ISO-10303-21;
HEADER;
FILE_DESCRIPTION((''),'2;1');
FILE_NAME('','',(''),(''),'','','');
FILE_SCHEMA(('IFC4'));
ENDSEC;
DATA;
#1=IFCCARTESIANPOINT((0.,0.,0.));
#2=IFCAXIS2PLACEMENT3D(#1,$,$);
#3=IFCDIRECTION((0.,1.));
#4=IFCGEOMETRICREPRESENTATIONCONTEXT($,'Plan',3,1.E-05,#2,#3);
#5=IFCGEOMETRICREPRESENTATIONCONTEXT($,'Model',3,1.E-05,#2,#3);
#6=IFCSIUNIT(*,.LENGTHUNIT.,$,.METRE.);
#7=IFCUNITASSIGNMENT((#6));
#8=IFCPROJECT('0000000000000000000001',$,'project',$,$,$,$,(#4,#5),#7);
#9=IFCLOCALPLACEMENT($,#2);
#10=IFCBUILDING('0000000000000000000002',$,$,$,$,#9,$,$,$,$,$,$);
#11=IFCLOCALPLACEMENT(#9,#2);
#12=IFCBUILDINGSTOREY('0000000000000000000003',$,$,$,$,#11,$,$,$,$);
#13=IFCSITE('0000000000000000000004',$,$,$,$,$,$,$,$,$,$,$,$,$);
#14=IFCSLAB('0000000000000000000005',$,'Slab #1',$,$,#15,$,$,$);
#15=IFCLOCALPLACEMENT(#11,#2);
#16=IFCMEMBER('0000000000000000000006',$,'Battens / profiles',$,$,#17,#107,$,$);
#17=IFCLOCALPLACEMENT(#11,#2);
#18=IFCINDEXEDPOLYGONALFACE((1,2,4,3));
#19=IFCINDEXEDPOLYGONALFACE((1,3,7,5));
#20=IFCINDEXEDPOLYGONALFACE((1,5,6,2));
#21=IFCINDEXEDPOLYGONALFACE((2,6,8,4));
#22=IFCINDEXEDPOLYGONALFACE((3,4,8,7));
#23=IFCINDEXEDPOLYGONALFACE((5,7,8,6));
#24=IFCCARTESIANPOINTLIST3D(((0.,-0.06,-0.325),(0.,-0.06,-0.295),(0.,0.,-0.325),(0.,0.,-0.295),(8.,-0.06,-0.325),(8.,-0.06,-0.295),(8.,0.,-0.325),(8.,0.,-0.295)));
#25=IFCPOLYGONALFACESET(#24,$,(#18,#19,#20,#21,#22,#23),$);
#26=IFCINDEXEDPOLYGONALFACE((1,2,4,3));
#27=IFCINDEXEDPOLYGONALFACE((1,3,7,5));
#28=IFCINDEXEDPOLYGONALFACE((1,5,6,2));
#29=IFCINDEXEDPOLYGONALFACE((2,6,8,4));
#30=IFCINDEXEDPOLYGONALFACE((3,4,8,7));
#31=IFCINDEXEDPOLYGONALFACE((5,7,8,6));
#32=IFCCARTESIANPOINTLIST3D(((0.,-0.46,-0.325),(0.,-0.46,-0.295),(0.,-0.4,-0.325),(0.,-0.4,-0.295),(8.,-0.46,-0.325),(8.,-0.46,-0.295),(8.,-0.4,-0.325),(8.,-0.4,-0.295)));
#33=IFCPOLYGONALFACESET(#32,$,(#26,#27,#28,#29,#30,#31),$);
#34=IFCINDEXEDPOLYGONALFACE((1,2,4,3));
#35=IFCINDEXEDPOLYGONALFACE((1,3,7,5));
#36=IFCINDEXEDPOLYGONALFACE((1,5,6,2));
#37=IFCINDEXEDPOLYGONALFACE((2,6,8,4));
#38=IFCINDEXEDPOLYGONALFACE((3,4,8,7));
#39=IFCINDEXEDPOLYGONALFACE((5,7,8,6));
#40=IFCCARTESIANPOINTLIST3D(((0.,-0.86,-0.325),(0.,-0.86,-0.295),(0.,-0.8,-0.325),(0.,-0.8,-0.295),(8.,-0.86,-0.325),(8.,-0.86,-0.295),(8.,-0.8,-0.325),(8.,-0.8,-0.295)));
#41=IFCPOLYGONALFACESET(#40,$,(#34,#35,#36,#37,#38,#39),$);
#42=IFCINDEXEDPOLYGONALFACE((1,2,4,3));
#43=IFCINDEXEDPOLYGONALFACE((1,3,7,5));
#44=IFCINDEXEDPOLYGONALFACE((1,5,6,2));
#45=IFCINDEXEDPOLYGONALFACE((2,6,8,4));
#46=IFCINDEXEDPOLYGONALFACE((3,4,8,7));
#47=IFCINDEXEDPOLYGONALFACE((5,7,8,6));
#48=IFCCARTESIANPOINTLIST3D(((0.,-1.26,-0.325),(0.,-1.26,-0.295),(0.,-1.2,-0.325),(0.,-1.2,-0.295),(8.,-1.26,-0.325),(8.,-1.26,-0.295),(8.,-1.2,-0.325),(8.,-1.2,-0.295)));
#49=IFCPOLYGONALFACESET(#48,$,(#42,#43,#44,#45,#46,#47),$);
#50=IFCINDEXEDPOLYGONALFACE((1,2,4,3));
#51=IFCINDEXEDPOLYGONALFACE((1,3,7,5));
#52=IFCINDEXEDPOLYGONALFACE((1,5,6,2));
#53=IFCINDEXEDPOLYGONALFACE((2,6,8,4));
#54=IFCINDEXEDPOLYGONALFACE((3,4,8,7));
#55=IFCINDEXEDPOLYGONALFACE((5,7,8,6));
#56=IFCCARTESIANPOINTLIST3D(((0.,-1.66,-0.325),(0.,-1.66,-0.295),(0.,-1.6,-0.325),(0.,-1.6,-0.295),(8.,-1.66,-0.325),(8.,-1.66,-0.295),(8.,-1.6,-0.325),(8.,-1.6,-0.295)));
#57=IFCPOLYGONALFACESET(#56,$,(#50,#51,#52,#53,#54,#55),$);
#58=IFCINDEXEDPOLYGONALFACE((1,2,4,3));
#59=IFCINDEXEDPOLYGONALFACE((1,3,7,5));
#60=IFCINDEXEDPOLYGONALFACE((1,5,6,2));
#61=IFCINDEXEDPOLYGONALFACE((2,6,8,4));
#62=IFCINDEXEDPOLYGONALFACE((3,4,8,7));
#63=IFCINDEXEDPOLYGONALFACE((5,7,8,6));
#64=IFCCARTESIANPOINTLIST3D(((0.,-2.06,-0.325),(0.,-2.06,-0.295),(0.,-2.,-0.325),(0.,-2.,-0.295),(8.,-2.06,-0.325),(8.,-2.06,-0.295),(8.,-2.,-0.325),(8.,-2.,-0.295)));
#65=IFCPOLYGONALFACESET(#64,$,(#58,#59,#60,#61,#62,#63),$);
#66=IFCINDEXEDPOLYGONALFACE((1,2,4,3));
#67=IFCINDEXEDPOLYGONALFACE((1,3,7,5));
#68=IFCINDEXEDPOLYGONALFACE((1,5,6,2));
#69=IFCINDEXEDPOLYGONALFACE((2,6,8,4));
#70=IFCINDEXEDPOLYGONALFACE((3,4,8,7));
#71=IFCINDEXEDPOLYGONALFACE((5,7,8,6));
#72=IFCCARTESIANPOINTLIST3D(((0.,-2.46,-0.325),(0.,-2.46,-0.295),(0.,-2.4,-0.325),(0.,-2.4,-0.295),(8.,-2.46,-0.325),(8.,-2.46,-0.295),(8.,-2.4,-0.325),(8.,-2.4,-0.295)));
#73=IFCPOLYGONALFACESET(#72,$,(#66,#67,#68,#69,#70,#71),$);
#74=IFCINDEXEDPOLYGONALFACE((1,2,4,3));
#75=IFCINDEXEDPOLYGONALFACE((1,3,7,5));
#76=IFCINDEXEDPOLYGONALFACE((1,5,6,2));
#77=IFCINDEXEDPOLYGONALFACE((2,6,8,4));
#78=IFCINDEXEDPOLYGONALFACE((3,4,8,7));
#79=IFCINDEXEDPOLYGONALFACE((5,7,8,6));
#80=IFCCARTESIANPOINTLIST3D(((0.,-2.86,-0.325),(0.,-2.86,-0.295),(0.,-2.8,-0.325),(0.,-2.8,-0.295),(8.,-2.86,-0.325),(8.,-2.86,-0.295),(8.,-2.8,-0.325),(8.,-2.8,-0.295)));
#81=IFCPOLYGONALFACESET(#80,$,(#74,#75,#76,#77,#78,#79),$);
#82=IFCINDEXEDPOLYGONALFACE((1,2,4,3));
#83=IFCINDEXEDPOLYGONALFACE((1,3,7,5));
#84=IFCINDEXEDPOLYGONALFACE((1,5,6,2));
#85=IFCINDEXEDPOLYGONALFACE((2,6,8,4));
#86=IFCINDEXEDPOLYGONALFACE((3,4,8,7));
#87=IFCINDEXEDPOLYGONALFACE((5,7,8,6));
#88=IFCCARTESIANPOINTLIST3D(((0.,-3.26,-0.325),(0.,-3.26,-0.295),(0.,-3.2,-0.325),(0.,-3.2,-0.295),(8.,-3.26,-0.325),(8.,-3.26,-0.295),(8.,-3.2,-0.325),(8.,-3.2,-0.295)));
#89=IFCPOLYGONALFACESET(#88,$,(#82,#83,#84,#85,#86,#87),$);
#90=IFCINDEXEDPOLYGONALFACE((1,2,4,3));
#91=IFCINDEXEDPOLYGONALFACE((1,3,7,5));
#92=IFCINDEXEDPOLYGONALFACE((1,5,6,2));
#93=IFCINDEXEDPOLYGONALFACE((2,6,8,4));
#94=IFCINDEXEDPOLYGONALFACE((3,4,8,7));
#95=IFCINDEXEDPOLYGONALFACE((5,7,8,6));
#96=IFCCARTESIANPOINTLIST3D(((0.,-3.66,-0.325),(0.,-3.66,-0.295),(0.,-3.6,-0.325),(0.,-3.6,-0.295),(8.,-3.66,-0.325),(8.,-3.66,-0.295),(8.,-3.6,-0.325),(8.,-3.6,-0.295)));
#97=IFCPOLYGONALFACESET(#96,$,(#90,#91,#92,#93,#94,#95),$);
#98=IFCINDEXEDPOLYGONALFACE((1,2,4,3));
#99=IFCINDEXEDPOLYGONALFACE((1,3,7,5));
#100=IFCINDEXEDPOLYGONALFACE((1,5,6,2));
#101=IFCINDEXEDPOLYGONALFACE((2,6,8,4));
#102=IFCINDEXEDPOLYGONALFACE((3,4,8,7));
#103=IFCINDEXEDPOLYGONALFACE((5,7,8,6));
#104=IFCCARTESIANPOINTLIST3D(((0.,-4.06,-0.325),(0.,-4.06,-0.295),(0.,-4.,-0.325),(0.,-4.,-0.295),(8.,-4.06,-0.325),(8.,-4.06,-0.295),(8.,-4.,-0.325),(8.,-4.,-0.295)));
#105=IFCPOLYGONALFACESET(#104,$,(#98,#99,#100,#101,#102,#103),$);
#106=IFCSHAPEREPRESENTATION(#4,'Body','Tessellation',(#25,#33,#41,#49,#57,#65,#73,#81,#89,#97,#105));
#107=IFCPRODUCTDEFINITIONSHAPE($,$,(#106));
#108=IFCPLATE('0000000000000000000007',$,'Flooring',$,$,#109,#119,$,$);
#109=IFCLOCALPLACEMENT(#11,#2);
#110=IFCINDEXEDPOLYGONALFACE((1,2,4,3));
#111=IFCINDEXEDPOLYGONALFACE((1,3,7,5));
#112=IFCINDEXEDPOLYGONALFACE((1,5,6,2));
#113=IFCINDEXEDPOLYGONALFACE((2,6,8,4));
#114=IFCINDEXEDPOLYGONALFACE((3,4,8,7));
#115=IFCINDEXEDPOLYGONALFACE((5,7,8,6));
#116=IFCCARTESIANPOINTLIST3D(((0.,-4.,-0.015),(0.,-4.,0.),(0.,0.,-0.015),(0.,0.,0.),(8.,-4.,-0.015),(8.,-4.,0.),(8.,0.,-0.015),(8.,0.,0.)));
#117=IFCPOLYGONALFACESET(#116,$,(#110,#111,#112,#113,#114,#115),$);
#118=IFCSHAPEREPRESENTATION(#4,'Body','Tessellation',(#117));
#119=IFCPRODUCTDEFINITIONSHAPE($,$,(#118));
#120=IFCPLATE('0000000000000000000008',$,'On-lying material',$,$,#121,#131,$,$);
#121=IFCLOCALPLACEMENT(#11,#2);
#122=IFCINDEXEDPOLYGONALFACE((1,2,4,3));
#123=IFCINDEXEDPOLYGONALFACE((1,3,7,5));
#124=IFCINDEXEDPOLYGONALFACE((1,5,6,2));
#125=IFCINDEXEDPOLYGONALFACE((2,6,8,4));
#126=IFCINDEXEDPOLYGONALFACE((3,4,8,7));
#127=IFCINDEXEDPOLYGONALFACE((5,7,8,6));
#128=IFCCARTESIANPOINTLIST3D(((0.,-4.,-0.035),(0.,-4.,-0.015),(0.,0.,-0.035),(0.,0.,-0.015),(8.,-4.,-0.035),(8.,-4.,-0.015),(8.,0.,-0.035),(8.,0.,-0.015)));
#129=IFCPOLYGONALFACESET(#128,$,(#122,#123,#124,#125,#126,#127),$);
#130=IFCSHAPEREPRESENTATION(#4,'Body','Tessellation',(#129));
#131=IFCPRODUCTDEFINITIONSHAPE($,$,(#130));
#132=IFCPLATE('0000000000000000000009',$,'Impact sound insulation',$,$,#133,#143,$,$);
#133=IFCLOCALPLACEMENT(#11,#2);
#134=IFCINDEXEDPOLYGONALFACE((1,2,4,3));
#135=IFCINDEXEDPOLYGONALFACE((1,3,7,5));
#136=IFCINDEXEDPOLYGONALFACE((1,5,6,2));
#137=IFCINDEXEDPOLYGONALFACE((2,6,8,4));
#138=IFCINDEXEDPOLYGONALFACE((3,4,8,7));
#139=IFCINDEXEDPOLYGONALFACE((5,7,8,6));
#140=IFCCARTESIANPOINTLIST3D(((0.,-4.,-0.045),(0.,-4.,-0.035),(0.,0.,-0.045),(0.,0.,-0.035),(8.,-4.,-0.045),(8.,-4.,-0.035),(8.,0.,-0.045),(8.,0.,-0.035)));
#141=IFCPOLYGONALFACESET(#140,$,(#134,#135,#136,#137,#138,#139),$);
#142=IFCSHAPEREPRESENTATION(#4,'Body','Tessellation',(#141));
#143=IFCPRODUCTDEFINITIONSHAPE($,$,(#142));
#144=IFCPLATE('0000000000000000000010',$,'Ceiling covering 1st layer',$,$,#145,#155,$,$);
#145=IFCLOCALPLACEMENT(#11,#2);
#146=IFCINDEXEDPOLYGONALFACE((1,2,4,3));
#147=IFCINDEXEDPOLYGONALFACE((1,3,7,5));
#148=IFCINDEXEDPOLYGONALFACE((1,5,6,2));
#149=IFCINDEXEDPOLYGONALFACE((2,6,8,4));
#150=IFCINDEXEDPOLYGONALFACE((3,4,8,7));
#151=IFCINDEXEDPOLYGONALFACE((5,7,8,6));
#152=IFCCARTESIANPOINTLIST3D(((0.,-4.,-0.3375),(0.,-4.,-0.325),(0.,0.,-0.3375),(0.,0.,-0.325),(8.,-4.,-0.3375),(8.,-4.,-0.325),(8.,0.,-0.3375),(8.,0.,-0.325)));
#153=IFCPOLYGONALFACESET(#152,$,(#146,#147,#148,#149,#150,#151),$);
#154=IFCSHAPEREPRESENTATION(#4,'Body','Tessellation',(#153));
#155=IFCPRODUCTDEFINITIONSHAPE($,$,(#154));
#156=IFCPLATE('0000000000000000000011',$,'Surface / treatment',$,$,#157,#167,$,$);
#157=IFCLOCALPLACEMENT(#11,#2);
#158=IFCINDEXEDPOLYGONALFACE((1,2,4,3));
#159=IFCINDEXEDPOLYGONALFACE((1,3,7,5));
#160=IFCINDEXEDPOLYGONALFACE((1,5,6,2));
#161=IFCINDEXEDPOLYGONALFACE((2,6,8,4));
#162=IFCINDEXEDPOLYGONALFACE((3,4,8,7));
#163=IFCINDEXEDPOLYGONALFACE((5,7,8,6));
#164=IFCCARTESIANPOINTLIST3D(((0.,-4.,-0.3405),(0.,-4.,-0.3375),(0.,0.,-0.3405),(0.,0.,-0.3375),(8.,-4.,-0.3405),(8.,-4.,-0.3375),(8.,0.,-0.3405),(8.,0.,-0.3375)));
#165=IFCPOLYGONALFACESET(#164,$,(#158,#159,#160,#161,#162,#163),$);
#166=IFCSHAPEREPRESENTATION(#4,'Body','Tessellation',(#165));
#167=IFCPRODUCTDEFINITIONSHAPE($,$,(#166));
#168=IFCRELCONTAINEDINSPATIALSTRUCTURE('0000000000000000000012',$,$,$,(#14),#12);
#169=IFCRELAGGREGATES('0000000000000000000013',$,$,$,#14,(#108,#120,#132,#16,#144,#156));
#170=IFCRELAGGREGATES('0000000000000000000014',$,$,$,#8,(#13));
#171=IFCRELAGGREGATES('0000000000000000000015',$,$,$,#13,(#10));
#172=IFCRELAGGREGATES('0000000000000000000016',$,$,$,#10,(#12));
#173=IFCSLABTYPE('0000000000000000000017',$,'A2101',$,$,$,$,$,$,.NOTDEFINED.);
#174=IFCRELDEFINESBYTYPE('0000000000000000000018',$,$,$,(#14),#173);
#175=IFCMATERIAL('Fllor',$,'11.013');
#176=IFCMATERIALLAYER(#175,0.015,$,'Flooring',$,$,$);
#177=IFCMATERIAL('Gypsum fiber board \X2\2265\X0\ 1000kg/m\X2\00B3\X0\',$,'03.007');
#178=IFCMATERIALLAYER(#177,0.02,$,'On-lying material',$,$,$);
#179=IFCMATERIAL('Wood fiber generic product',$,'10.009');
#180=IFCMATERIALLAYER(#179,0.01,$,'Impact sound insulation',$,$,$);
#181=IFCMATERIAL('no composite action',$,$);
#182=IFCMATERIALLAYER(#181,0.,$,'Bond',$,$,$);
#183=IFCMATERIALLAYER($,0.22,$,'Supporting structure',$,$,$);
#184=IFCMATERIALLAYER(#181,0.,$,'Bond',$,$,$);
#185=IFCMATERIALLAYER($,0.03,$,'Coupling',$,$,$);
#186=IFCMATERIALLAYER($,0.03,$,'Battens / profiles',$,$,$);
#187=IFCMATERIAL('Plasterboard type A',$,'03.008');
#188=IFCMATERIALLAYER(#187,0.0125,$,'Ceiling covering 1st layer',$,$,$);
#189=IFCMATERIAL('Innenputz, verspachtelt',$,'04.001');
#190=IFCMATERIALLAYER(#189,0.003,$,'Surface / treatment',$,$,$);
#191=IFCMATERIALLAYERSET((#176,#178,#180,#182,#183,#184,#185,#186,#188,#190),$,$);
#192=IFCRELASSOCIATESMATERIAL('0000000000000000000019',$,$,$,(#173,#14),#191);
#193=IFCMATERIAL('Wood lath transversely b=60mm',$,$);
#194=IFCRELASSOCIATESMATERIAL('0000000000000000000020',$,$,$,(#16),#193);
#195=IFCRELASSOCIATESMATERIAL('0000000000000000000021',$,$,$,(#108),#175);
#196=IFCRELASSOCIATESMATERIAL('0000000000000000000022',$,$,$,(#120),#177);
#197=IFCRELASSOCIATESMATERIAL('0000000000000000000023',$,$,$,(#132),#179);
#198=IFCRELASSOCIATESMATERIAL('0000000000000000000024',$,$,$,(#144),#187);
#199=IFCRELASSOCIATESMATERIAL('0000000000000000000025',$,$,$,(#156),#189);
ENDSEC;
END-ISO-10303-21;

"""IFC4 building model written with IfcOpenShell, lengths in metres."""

from ifc_helpers import new_model, si_unit, direction, frame, frame_2d, origin, origin_with_axes, place, context, project, spatial, rectangle, extrude, material, layer, layer_set, type_object, element, aggregate, save


model = new_model("IFC4")

# Units and contexts
plan_context = context("Plan", 3, precision=1e-05, world=origin(), true_north=direction((0.0, 1.0)))
model_context = context("Model", 3, precision=1e-05, world=origin(), true_north=direction((0.0, 1.0)))
ifc_project = project(units=[si_unit("LENGTHUNIT", "METRE")], contexts=[plan_context, model_context])

# Site, building, storey
site = spatial("IfcSite", under=ifc_project)
building_placement = place(None, origin())
building = spatial("IfcBuilding", under=site, at=building_placement)
storey_placement = place(building_placement, origin())
storey = spatial("IfcBuildingStorey", under=building, at=storey_placement)

# Slab, member, plates
ifc_material_1 = material(Name="Fllor", Category="11.013")
ifc_layer_1 = layer(ifc_material_1, 0.015, Name="Flooring")
ifc_material_2 = material(Name="Gypsum fiber board ≥ 1000kg/m³", Category="03.007")
ifc_layer_2 = layer(ifc_material_2, 0.02, Name="On-lying material")
ifc_material_3 = material(Name="Wood fiber generic product", Category="10.009")
ifc_layer_3 = layer(ifc_material_3, 0.01, Name="Impact sound insulation")
ifc_material_4 = material(Name="no composite action")
ifc_layer_4 = layer(ifc_material_4, 0.0, Name="Bond")
ifc_layer_5 = layer(None, 0.22, Name="Supporting structure")
ifc_layer_6 = layer(ifc_material_4, 0.0, Name="Bond")
ifc_layer_7 = layer(None, 0.03, Name="Coupling")
ifc_layer_8 = layer(None, 0.03, Name="Battens / profiles")
ifc_material_5 = material(Name="Plasterboard type A", Category="03.008")
ifc_layer_9 = layer(ifc_material_5, 0.0125, Name="Ceiling covering 1st layer")
ifc_material_6 = material(Name="Innenputz, verspachtelt", Category="04.001")
ifc_layer_10 = layer(ifc_material_6, 0.003, Name="Surface / treatment")
ifc_layer_set = layer_set([ifc_layer_1, ifc_layer_2, ifc_layer_3, ifc_layer_4, ifc_layer_5, ifc_layer_6, ifc_layer_7, ifc_layer_8, ifc_layer_9, ifc_layer_10])
slab_type = type_object("IfcSlabType", Name="A2101", PredefinedType="NOTDEFINED", material=ifc_layer_set)
slab_placement = place(None, frame((0.0, 0.0, 0.0), z_axis=(0.0, 0.0, -1.0), x_axis=(1.0, 0.0, 0.0)))
slab = element("IfcSlab", 1, at=slab_placement, inside=storey, type_object=slab_type, material=ifc_layer_set, Name="Slab #1")
ifc_material_7 = material(Name="Wood lath transversely b=60mm")
member_1_placement = place(slab_placement, origin())
member_1 = element("IfcMember", 2, at=member_1_placement, material=ifc_material_7, Name="Battens / profiles", context=plan_context, shape_type="SweptSolid", body=[
    extrude(rectangle(XDim=0.06, YDim=0.03, at=frame_2d((0.03, 0.015), x_axis=(1.0, 0.0))), frame((0.0, 0.0, 0.295), z_axis=(1.0, 0.0, 0.0), x_axis=(0.0, 1.0, 0.0)), (0.0, 0.0, 1.0), 8.0),
    extrude(rectangle(XDim=0.06, YDim=0.03, at=frame_2d((0.03, 0.015), x_axis=(1.0, 0.0))), frame((0.0, 0.4, 0.295), z_axis=(1.0, 0.0, 0.0), x_axis=(0.0, 1.0, 0.0)), (0.0, 0.0, 1.0), 8.0),
    extrude(rectangle(XDim=0.06, YDim=0.03, at=frame_2d((0.03, 0.015), x_axis=(1.0, 0.0))), frame((0.0, 0.8, 0.295), z_axis=(1.0, 0.0, 0.0), x_axis=(0.0, 1.0, 0.0)), (0.0, 0.0, 1.0), 8.0),
    extrude(rectangle(XDim=0.06, YDim=0.03, at=frame_2d((0.03, 0.015), x_axis=(1.0, 0.0))), frame((0.0, 1.2, 0.295), z_axis=(1.0, 0.0, 0.0), x_axis=(0.0, 1.0, 0.0)), (0.0, 0.0, 1.0), 8.0),
    extrude(rectangle(XDim=0.06, YDim=0.03, at=frame_2d((0.03, 0.015), x_axis=(1.0, 0.0))), frame((0.0, 1.6, 0.295), z_axis=(1.0, 0.0, 0.0), x_axis=(0.0, 1.0, 0.0)), (0.0, 0.0, 1.0), 8.0),
    extrude(rectangle(XDim=0.06, YDim=0.03, at=frame_2d((0.03, 0.015), x_axis=(1.0, 0.0))), frame((0.0, 2.0, 0.295), z_axis=(1.0, 0.0, 0.0), x_axis=(0.0, 1.0, 0.0)), (0.0, 0.0, 1.0), 8.0),
    extrude(rectangle(XDim=0.06, YDim=0.03, at=frame_2d((0.03, 0.015), x_axis=(1.0, 0.0))), frame((0.0, 2.4, 0.295), z_axis=(1.0, 0.0, 0.0), x_axis=(0.0, 1.0, 0.0)), (0.0, 0.0, 1.0), 8.0),
    extrude(rectangle(XDim=0.06, YDim=0.03, at=frame_2d((0.03, 0.015), x_axis=(1.0, 0.0))), frame((0.0, 2.8, 0.295), z_axis=(1.0, 0.0, 0.0), x_axis=(0.0, 1.0, 0.0)), (0.0, 0.0, 1.0), 8.0),
    extrude(rectangle(XDim=0.06, YDim=0.03, at=frame_2d((0.03, 0.015), x_axis=(1.0, 0.0))), frame((0.0, 3.2, 0.295), z_axis=(1.0, 0.0, 0.0), x_axis=(0.0, 1.0, 0.0)), (0.0, 0.0, 1.0), 8.0),
    extrude(rectangle(XDim=0.06, YDim=0.03, at=frame_2d((0.03, 0.015), x_axis=(1.0, 0.0))), frame((0.0, 3.6, 0.295), z_axis=(1.0, 0.0, 0.0), x_axis=(0.0, 1.0, 0.0)), (0.0, 0.0, 1.0), 8.0),
    extrude(rectangle(XDim=0.06, YDim=0.03, at=frame_2d((0.03, 0.015), x_axis=(1.0, 0.0))), frame((0.0, 4.0, 0.295), z_axis=(1.0, 0.0, 0.0), x_axis=(0.0, 1.0, 0.0)), (0.0, 0.0, 1.0), 8.0),
])
plate_1_placement = place(slab_placement, origin())
plate_1 = element("IfcPlate", 3, at=plate_1_placement, material=ifc_material_1, Name="Flooring", context=plan_context, shape_type="SweptSolid", body=[
    extrude(rectangle(XDim=8.0, YDim=4.0, at=frame_2d((4.0, 2.0), x_axis=(1.0, 0.0))), origin_with_axes(), (0.0, 0.0, 1.0), 0.015),
])
plate_2_placement = place(slab_placement, origin())
plate_2 = element("IfcPlate", 4, at=plate_2_placement, material=ifc_material_2, Name="On-lying material", context=plan_context, shape_type="SweptSolid", body=[
    extrude(rectangle(XDim=8.0, YDim=4.0, at=frame_2d((4.0, 2.0), x_axis=(1.0, 0.0))), frame((0.0, 0.0, 0.015), z_axis=(0.0, 0.0, 1.0), x_axis=(1.0, 0.0, 0.0)), (0.0, 0.0, 1.0), 0.02),
])
plate_3_placement = place(slab_placement, origin())
plate_3 = element("IfcPlate", 5, at=plate_3_placement, material=ifc_material_3, Name="Impact sound insulation", context=plan_context, shape_type="SweptSolid", body=[
    extrude(rectangle(XDim=8.0, YDim=4.0, at=frame_2d((4.0, 2.0), x_axis=(1.0, 0.0))), frame((0.0, 0.0, 0.035), z_axis=(0.0, 0.0, 1.0), x_axis=(1.0, 0.0, 0.0)), (0.0, 0.0, 1.0), 0.01),
])
plate_4_placement = place(slab_placement, origin())
plate_4 = element("IfcPlate", 6, at=plate_4_placement, material=ifc_material_5, Name="Ceiling covering 1st layer", context=plan_context, shape_type="SweptSolid", body=[
    extrude(rectangle(XDim=8.0, YDim=4.0, at=frame_2d((4.0, 2.0), x_axis=(1.0, 0.0))), frame((0.0, 0.0, 0.325), z_axis=(0.0, 0.0, 1.0), x_axis=(1.0, 0.0, 0.0)), (0.0, 0.0, 1.0), 0.0125),
])
plate_5_placement = place(slab_placement, origin())
plate_5 = element("IfcPlate", 7, at=plate_5_placement, material=ifc_material_6, Name="Surface / treatment", context=plan_context, shape_type="SweptSolid", body=[
    extrude(rectangle(XDim=8.0, YDim=4.0, at=frame_2d((4.0, 2.0), x_axis=(1.0, 0.0))), frame((0.0, 0.0, 0.3375), z_axis=(0.0, 0.0, 1.0), x_axis=(1.0, 0.0, 0.0)), (0.0, 0.0, 1.0), 0.003),
])
aggregate(slab, [plate_1, plate_2, plate_3, member_1, plate_4, plate_5])

save(model, "model.ifc")
